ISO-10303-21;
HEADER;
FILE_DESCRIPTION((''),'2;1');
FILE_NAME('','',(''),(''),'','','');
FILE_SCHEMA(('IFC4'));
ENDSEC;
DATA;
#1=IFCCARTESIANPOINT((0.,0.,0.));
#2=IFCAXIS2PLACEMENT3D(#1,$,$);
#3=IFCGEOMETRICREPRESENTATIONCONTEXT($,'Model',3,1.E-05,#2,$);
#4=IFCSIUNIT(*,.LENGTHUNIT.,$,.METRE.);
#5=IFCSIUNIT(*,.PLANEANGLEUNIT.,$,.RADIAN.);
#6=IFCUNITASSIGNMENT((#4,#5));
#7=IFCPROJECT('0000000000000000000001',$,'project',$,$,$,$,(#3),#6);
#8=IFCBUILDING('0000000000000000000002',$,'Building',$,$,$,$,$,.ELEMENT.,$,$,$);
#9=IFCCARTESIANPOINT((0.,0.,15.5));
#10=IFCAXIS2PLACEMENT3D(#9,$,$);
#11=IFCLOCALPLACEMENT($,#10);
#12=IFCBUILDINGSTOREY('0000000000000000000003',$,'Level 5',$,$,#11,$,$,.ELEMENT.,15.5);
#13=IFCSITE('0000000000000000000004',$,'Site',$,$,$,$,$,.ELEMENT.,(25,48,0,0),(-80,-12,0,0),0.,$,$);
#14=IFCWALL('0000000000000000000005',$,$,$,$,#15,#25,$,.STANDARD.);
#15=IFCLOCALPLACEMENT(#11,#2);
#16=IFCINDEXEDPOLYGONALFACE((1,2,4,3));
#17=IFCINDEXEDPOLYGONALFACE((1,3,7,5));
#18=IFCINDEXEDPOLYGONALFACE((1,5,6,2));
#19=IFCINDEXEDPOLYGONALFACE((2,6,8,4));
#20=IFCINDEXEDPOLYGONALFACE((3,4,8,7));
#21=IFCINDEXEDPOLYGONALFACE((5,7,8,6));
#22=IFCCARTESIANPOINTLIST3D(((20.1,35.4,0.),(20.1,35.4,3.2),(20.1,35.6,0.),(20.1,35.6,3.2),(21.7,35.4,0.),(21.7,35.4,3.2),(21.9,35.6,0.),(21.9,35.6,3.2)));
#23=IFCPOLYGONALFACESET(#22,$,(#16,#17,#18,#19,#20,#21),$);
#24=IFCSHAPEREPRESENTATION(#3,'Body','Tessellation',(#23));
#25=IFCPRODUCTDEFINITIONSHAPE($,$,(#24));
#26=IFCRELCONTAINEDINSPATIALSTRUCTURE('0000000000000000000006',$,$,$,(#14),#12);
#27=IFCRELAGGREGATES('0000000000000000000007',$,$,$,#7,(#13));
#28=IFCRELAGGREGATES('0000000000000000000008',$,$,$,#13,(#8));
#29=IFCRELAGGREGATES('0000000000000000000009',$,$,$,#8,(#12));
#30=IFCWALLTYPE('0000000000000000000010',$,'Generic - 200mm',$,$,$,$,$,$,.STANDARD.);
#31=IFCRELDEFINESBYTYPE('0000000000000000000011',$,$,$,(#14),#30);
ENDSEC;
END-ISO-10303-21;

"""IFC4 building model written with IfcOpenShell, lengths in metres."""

from ifc_helpers import new_model, si_unit, frame, origin, place, context, project, spatial, polyline, outline, extrude, type_object, element, save


model = new_model("IFC4")

# Units and contexts
model_context = context("Model", 3, precision=1e-05, world=origin())
ifc_project = project(units=[si_unit("LENGTHUNIT", "METRE"), si_unit("PLANEANGLEUNIT", "RADIAN")], contexts=[model_context])

# Site, building, storey
site = spatial("IfcSite", under=ifc_project, Name="Site", CompositionType="ELEMENT", RefLatitude=(25, 48, 0, 0), RefLongitude=(-80, -12, 0, 0), RefElevation=0.0)
building = spatial("IfcBuilding", under=site, Name="Building", CompositionType="ELEMENT")
storey_placement = place(None, frame((0.0, 0.0, 15.5)))
storey = spatial("IfcBuildingStorey", under=building, at=storey_placement, Name="Level 5", CompositionType="ELEMENT", Elevation=15.5)

# Shared definitions
wall_type = type_object("IfcWallType", Name="Generic - 200mm", PredefinedType="STANDARD")

# Wall
wall_1_placement = place(None, frame((21.8, 35.5, 15.5), z_axis=(0.0, 0.0, 1.0), x_axis=(-1.0, 0.0, 0.0)))
element("IfcWall", 1, at=wall_1_placement, inside=storey, type_object=wall_type, PredefinedType="STANDARD", context=model_context, shape_type="SweptSolid", body=[
    extrude(outline(polyline([(-0.1, -0.1), (1.7, -0.1), (1.7, 0.1), (0.1, 0.1), (-0.1, -0.1)])), origin(), (0.0, 0.0, 1.0), 3.2),
])

save(model, "model.ifc")
